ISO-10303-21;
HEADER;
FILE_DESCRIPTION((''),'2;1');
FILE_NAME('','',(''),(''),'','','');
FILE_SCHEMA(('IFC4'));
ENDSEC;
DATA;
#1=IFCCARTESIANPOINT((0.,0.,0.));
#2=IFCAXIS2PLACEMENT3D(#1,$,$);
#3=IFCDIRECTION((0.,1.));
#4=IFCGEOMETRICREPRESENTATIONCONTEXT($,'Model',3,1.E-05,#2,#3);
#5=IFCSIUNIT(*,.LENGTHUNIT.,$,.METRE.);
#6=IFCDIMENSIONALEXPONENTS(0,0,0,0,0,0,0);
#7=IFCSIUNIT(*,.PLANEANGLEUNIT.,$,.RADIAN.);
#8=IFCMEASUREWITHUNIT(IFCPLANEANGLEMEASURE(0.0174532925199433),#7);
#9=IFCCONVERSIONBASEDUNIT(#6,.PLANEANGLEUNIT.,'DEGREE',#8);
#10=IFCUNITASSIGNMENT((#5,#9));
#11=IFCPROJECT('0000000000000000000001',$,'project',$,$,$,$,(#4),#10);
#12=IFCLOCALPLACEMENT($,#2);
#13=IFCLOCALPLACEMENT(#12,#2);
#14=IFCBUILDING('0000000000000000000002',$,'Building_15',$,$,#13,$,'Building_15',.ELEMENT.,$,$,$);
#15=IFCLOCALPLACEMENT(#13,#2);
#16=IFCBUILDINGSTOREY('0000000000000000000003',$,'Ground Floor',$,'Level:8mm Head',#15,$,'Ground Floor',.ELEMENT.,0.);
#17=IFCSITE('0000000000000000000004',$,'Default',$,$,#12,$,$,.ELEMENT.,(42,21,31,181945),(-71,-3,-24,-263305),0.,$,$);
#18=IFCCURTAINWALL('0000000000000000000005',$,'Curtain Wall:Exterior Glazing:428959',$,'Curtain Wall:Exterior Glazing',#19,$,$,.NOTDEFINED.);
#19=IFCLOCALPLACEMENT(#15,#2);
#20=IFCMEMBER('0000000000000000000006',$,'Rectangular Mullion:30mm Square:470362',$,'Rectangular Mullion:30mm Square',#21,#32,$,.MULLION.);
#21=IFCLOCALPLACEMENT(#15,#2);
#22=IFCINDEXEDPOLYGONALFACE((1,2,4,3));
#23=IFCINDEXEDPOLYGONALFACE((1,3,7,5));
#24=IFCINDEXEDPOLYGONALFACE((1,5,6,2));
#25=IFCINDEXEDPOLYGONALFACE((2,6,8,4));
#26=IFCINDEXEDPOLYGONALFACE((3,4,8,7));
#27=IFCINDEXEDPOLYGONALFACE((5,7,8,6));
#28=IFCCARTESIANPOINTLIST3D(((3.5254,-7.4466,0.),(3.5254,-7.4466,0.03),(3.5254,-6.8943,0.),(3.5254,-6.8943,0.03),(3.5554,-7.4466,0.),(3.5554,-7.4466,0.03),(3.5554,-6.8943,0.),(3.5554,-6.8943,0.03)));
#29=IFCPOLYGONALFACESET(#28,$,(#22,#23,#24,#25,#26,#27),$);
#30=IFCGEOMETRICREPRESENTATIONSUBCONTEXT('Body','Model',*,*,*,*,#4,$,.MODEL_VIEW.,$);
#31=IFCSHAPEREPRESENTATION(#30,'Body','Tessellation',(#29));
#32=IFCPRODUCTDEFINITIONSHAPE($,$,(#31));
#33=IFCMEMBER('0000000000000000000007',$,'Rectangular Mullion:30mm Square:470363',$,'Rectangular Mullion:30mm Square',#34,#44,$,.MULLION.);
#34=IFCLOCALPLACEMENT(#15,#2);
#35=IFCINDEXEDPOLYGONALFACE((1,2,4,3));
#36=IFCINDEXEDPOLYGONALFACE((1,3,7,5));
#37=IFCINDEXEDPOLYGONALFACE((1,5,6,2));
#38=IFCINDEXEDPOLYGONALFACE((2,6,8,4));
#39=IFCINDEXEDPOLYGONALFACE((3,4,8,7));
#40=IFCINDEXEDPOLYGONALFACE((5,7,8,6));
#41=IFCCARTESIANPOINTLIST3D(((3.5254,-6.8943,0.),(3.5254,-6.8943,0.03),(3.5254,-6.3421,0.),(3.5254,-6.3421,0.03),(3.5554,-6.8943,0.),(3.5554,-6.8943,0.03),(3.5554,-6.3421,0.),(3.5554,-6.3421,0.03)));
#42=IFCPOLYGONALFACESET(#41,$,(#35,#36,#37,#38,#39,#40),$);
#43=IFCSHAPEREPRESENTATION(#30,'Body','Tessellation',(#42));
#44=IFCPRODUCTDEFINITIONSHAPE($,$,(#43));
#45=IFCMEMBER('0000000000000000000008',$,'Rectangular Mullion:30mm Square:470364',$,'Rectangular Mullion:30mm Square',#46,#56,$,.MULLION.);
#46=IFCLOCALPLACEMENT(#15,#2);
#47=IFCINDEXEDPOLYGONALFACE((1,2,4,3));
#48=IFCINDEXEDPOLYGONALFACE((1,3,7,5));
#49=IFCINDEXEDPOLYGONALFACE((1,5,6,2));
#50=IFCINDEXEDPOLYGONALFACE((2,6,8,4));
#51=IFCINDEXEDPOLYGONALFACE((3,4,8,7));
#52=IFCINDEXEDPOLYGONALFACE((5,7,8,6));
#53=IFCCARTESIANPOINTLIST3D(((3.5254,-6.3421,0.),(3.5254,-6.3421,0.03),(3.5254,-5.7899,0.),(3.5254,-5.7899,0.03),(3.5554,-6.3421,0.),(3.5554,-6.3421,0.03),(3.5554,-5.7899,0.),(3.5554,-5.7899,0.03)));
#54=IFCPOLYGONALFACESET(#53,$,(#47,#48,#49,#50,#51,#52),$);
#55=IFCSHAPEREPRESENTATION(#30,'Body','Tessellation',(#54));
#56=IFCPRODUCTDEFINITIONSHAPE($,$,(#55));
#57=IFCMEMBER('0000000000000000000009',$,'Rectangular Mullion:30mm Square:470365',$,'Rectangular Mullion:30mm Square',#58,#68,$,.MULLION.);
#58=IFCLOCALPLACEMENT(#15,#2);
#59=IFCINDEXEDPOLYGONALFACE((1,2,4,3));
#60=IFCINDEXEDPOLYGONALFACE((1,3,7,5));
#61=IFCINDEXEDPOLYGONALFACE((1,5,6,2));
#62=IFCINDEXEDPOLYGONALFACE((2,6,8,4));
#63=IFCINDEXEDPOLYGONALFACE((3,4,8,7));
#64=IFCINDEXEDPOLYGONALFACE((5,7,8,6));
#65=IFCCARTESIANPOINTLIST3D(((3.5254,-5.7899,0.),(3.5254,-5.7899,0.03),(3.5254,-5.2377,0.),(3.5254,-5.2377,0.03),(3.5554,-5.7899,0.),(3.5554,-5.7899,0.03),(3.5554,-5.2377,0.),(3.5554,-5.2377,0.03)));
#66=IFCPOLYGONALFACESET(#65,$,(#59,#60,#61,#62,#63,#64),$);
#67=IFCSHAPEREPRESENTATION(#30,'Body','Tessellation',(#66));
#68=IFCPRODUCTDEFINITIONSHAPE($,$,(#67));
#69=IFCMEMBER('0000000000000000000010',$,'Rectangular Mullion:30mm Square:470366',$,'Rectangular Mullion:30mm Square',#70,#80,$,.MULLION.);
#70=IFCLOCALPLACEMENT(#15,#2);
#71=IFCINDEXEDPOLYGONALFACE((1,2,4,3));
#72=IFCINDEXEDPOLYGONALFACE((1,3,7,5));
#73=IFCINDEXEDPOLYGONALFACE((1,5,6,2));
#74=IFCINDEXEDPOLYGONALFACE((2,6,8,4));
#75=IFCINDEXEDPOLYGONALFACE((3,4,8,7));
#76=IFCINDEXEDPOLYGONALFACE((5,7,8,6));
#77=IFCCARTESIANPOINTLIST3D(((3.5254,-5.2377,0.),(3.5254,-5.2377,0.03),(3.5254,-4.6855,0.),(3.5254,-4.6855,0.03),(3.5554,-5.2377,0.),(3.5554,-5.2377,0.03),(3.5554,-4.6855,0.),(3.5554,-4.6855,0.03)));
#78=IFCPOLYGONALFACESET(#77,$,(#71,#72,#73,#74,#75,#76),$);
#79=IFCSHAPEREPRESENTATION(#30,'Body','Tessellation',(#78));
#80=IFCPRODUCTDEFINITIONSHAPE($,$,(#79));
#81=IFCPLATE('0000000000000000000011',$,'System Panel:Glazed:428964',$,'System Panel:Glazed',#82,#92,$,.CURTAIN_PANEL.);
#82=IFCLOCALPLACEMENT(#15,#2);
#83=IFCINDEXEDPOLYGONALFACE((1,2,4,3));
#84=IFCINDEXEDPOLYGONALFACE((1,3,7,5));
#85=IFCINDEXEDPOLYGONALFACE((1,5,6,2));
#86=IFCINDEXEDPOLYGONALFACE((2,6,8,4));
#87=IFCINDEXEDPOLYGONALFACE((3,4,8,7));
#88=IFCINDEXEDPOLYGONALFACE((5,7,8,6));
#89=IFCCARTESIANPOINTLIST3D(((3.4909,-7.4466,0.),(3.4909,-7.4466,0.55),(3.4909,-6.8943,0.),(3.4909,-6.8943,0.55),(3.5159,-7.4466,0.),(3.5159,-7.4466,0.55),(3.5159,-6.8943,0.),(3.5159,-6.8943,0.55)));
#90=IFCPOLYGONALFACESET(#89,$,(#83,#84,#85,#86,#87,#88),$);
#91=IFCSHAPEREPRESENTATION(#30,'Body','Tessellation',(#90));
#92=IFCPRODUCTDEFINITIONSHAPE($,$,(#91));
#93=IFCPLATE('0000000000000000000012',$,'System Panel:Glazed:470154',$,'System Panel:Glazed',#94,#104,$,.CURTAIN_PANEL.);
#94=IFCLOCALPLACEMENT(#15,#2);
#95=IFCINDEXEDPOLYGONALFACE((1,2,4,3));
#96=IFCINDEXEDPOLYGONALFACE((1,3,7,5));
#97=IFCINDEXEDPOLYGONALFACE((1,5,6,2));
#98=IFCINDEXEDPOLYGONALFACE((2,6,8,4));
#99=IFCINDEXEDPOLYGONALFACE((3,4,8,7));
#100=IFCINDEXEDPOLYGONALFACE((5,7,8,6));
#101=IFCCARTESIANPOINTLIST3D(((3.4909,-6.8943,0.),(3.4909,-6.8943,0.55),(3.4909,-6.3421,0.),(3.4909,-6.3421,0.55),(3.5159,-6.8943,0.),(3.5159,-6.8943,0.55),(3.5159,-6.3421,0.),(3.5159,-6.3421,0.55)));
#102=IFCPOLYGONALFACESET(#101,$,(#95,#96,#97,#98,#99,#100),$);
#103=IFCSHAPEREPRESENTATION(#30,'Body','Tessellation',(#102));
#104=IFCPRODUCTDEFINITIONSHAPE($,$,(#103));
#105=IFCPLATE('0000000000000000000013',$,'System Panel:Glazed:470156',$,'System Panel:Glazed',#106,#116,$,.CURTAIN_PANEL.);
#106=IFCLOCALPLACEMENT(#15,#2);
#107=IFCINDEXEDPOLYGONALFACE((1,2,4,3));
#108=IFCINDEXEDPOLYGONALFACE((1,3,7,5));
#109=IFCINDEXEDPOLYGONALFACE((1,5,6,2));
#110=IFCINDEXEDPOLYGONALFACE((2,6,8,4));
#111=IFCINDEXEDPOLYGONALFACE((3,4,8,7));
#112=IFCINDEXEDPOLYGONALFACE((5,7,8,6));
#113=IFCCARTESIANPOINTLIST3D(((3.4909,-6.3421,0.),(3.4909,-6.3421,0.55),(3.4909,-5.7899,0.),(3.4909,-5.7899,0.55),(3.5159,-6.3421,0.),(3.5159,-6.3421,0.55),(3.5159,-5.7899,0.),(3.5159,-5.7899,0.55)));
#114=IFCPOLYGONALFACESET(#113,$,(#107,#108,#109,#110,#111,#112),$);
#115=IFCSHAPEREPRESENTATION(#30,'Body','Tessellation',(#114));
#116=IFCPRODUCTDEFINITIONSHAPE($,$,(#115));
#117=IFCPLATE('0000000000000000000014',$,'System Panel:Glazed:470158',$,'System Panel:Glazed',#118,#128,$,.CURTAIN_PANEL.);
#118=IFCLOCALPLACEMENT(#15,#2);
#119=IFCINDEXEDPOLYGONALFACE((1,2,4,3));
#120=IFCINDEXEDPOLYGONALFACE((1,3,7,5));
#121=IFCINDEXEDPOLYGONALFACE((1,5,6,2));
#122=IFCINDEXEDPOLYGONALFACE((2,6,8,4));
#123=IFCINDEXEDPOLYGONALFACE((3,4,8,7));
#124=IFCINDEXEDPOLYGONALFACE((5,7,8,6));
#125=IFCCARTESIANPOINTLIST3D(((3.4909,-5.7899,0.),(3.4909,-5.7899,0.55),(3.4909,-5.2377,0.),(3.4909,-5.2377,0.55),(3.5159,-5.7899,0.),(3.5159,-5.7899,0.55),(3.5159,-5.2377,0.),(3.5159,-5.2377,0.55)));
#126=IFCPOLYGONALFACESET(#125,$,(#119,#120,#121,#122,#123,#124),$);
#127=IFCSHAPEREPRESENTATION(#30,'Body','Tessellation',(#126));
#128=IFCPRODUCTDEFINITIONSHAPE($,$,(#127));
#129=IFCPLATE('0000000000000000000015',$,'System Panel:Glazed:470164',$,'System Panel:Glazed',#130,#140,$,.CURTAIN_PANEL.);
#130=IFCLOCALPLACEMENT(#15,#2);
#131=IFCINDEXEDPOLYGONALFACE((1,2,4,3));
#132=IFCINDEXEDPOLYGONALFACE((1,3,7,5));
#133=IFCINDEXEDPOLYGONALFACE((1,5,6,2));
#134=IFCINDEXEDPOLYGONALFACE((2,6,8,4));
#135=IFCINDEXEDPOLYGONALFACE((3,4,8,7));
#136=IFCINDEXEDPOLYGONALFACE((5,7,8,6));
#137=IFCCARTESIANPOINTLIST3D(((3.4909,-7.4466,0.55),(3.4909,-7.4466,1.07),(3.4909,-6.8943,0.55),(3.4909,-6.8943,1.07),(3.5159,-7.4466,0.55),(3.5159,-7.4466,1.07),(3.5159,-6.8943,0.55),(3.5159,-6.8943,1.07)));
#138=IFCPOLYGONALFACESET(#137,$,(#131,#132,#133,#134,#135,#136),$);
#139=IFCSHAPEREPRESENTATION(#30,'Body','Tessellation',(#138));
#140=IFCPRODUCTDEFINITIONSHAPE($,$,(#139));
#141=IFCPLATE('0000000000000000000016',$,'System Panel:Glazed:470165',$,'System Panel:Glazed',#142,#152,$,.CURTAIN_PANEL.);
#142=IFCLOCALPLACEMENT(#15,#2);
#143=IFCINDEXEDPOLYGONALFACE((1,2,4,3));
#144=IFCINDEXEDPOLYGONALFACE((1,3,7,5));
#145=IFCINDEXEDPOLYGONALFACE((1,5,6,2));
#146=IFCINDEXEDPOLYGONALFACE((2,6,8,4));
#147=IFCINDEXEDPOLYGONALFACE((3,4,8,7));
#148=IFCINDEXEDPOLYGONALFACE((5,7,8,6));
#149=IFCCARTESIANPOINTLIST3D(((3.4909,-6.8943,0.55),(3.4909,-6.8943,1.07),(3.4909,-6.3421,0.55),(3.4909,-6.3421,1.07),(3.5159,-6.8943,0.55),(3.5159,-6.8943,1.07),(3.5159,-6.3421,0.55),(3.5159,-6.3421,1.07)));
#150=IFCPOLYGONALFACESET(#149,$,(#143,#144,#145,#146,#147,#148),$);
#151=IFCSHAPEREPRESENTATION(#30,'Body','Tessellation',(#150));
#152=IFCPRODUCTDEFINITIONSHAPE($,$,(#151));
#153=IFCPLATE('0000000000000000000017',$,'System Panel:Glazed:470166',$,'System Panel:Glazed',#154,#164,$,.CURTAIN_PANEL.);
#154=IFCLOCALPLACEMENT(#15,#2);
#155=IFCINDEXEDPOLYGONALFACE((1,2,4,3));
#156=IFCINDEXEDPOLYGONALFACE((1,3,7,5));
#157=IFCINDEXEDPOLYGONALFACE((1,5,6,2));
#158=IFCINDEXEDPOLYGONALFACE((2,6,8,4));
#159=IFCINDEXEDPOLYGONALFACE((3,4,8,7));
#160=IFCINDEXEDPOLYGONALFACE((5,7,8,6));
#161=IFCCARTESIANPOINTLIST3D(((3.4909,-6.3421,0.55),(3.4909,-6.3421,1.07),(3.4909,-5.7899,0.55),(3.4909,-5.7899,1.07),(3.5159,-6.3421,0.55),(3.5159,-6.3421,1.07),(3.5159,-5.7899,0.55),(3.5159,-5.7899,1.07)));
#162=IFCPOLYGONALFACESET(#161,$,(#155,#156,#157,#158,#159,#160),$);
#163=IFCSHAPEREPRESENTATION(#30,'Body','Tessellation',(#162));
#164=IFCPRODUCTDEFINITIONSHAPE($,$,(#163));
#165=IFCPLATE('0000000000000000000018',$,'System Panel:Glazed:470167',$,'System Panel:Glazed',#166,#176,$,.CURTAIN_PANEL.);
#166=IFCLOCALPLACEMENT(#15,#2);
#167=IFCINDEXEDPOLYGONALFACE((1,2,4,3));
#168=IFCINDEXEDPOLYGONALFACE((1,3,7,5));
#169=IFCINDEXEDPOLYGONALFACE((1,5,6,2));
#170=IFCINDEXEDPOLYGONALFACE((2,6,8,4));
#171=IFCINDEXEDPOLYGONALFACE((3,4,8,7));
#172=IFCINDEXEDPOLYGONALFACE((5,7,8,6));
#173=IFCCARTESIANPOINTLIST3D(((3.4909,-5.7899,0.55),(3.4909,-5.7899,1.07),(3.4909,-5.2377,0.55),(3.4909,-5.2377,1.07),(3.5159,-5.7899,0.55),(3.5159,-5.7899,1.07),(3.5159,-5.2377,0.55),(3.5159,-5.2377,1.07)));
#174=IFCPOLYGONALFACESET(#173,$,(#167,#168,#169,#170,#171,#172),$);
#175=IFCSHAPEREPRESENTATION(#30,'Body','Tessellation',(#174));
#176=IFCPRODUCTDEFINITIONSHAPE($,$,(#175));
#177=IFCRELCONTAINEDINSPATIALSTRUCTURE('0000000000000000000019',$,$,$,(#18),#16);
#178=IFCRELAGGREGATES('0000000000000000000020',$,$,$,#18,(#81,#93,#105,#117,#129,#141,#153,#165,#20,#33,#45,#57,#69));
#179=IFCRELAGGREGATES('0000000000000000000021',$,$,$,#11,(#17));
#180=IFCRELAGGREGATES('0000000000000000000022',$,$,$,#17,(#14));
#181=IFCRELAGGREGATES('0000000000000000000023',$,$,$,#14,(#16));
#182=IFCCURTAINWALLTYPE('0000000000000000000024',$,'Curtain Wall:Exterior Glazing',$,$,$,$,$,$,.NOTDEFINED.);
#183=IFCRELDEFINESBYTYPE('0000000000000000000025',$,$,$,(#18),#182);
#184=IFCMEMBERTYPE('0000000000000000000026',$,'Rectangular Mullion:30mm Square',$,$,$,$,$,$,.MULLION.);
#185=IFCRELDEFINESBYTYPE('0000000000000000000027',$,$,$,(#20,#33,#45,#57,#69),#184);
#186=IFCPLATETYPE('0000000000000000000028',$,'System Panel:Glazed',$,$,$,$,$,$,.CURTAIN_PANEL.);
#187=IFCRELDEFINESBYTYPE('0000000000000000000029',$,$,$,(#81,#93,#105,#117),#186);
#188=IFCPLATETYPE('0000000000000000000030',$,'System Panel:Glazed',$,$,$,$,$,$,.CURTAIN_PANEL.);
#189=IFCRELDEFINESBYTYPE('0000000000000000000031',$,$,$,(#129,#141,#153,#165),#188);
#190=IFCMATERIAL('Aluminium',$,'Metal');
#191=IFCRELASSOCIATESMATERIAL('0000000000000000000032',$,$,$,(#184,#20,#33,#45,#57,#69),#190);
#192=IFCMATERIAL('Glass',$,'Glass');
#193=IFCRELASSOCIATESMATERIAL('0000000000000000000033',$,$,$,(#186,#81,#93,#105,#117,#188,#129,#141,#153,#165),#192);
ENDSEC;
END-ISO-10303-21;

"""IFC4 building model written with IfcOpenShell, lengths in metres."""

from ifc_helpers import new_model, entity, si_unit, converted_unit, direction, frame, origin, place, context, subcontext, project, spatial, indexed_curve, outline, extrude, source, transform, mapped, material, type_object, type_shapes, element, aggregate, save


model = new_model("IFC4")

# Units and contexts
model_context = context("Model", 3, precision=1e-05, world=origin(), true_north=direction((0.0, 1.0)))
body_context = subcontext(model_context, "Body", "Model", "MODEL_VIEW")
ifc_project = project(units=[si_unit("LENGTHUNIT", "METRE"), converted_unit("PLANEANGLEUNIT", "DEGREE", entity("IfcPlaneAngleMeasure", 0.0174532925199433), si_unit("PLANEANGLEUNIT", "RADIAN"), dimensions=[0, 0, 0, 0, 0, 0, 0])], contexts=[model_context])

# Site, building, storey
site_placement = place(None, origin())
site = spatial("IfcSite", under=ifc_project, at=site_placement, Name="Default", CompositionType="ELEMENT", RefLatitude=(42, 21, 31, 181945), RefLongitude=(-71, -3, -24, -263305), RefElevation=0.0)
building_placement = place(site_placement, origin())
building = spatial("IfcBuilding", under=site, at=building_placement, Name="Building_15", LongName="Building_15", CompositionType="ELEMENT")
storey_placement = place(building_placement, origin())
storey = spatial("IfcBuildingStorey", under=building, at=storey_placement, Name="Ground Floor", ObjectType="Level:8mm Head", LongName="Ground Floor", CompositionType="ELEMENT", Elevation=0.0)

# Curtain wall, members, plates
curtain_wall_type = type_object("IfcCurtainWallType", Name="Curtain Wall:Exterior Glazing", PredefinedType="NOTDEFINED")
curtain_wall_placement = place(storey_placement, origin())
curtain_wall = element("IfcCurtainWall", 1, at=curtain_wall_placement, inside=storey, type_object=curtain_wall_type, Name="Curtain Wall:Exterior Glazing:428959", ObjectType="Curtain Wall:Exterior Glazing", PredefinedType="NOTDEFINED")
ifc_material_1 = material(Name="Aluminium", Category="Metal")
member_type = type_object("IfcMemberType", Name="Rectangular Mullion:30mm Square", PredefinedType="MULLION", material=ifc_material_1)
shared_shape_1 = source(origin(), body_context, "Body", "SweptSolid", [
    extrude(outline(indexed_curve([(-0.015, -0.015), (0.015, -0.015), (0.015, 0.015), (-0.015, 0.015), (-0.015, -0.015)], self_intersect=False)), frame((-0.015, 0.0, -0.5522), z_axis=(0.0, 0.0, 1.0), x_axis=(-1.0, 0.0, 0.0)), (0.0, 0.0, 1.0), 0.5522),
])
type_shapes(member_type, [shared_shape_1])
member_1_placement = place(curtain_wall_placement, frame((3.5404, -7.4466, 0.0), z_axis=(0.0, -1.0, 0.0), x_axis=(0.0, 0.0, -1.0)))
member_1 = element("IfcMember", 2, at=member_1_placement, type_object=member_type, material=ifc_material_1, Name="Rectangular Mullion:30mm Square:470362", ObjectType="Rectangular Mullion:30mm Square", PredefinedType="MULLION", context=body_context, shape_type="MappedRepresentation", body=[
    mapped(shared_shape_1, transform((0.0, 0.0, 0.0), scale=1.0)),
])
member_2_placement = place(curtain_wall_placement, frame((3.5404, -6.8943, 0.0), z_axis=(0.0, -1.0, 0.0), x_axis=(0.0, 0.0, -1.0)))
member_2 = element("IfcMember", 3, at=member_2_placement, type_object=member_type, material=ifc_material_1, Name="Rectangular Mullion:30mm Square:470363", ObjectType="Rectangular Mullion:30mm Square", PredefinedType="MULLION", context=body_context, shape_type="MappedRepresentation", body=[
    mapped(shared_shape_1, transform((0.0, 0.0, 0.0), scale=1.0)),
])
member_3_placement = place(curtain_wall_placement, frame((3.5404, -6.3421, 0.0), z_axis=(0.0, -1.0, 0.0), x_axis=(0.0, 0.0, -1.0)))
member_3 = element("IfcMember", 4, at=member_3_placement, type_object=member_type, material=ifc_material_1, Name="Rectangular Mullion:30mm Square:470364", ObjectType="Rectangular Mullion:30mm Square", PredefinedType="MULLION", context=body_context, shape_type="MappedRepresentation", body=[
    mapped(shared_shape_1, transform((0.0, 0.0, 0.0), scale=1.0)),
])
member_4_placement = place(curtain_wall_placement, frame((3.5404, -5.7899, 0.0), z_axis=(0.0, -1.0, 0.0), x_axis=(0.0, 0.0, -1.0)))
member_4 = element("IfcMember", 5, at=member_4_placement, type_object=member_type, material=ifc_material_1, Name="Rectangular Mullion:30mm Square:470365", ObjectType="Rectangular Mullion:30mm Square", PredefinedType="MULLION", context=body_context, shape_type="MappedRepresentation", body=[
    mapped(shared_shape_1, transform((0.0, 0.0, 0.0), scale=1.0)),
])
member_5_placement = place(curtain_wall_placement, frame((3.5404, -5.2377, 0.0), z_axis=(0.0, -1.0, 0.0), x_axis=(0.0, 0.0, -1.0)))
member_5 = element("IfcMember", 6, at=member_5_placement, type_object=member_type, material=ifc_material_1, Name="Rectangular Mullion:30mm Square:470366", ObjectType="Rectangular Mullion:30mm Square", PredefinedType="MULLION", context=body_context, shape_type="MappedRepresentation", body=[
    mapped(shared_shape_1, transform((0.0, 0.0, 0.0), scale=1.0)),
])
ifc_material_2 = material(Name="Glass", Category="Glass")
plate_type_1 = type_object("IfcPlateType", Name="System Panel:Glazed", PredefinedType="CURTAIN_PANEL", material=ifc_material_2)
shared_shape_2 = source(origin(), body_context, "Body", "SweptSolid", [
    extrude(outline(indexed_curve([(-0.0125, -0.2761), (0.0125, -0.2761), (0.0125, 0.2761), (-0.0125, 0.2761), (-0.0125, -0.2761)], self_intersect=False)), frame((0.0, 0.037, 0.0), z_axis=(0.0, 0.0, 1.0), x_axis=(0.0, 1.0, 0.0)), (0.0, 0.0, 1.0), 0.55),
])
type_shapes(plate_type_1, [shared_shape_2])
plate_1_placement = place(curtain_wall_placement, frame((3.5404, -7.1705, 0.0), z_axis=(0.0, 0.0, 1.0), x_axis=(0.0, 1.0, 0.0)))
plate_1 = element("IfcPlate", 7, at=plate_1_placement, type_object=plate_type_1, material=ifc_material_2, Name="System Panel:Glazed:428964", ObjectType="System Panel:Glazed", PredefinedType="CURTAIN_PANEL", context=body_context, shape_type="MappedRepresentation", body=[
    mapped(shared_shape_2, transform((0.0, 0.0, 0.0), scale=1.0)),
])
plate_2_placement = place(curtain_wall_placement, frame((3.5404, -6.6182, 0.0), z_axis=(0.0, 0.0, 1.0), x_axis=(0.0, 1.0, 0.0)))
plate_2 = element("IfcPlate", 8, at=plate_2_placement, type_object=plate_type_1, material=ifc_material_2, Name="System Panel:Glazed:470154", ObjectType="System Panel:Glazed", PredefinedType="CURTAIN_PANEL", context=body_context, shape_type="MappedRepresentation", body=[
    mapped(shared_shape_2, transform((0.0, 0.0, 0.0), scale=1.0)),
])
plate_3_placement = place(curtain_wall_placement, frame((3.5404, -6.066, 0.0), z_axis=(0.0, 0.0, 1.0), x_axis=(0.0, 1.0, 0.0)))
plate_3 = element("IfcPlate", 9, at=plate_3_placement, type_object=plate_type_1, material=ifc_material_2, Name="System Panel:Glazed:470156", ObjectType="System Panel:Glazed", PredefinedType="CURTAIN_PANEL", context=body_context, shape_type="MappedRepresentation", body=[
    mapped(shared_shape_2, transform((0.0, 0.0, 0.0), scale=1.0)),
])
plate_4_placement = place(curtain_wall_placement, frame((3.5404, -5.5138, 0.0), z_axis=(0.0, 0.0, 1.0), x_axis=(0.0, 1.0, 0.0)))
plate_4 = element("IfcPlate", 10, at=plate_4_placement, type_object=plate_type_1, material=ifc_material_2, Name="System Panel:Glazed:470158", ObjectType="System Panel:Glazed", PredefinedType="CURTAIN_PANEL", context=body_context, shape_type="MappedRepresentation", body=[
    mapped(shared_shape_2, transform((0.0, 0.0, 0.0), scale=1.0)),
])
plate_type_2 = type_object("IfcPlateType", Name="System Panel:Glazed", PredefinedType="CURTAIN_PANEL", material=ifc_material_2)
shared_shape_3 = source(origin(), body_context, "Body", "SweptSolid", [
    extrude(outline(indexed_curve([(-0.0125, -0.2761), (0.0125, -0.2761), (0.0125, 0.2761), (-0.0125, 0.2761), (-0.0125, -0.2761)], self_intersect=False)), frame((0.0, 0.037, 0.0), z_axis=(0.0, 0.0, 1.0), x_axis=(0.0, 1.0, 0.0)), (0.0, 0.0, 1.0), 0.52),
])
type_shapes(plate_type_2, [shared_shape_3])
plate_5_placement = place(curtain_wall_placement, frame((3.5404, -7.1705, 0.55), z_axis=(0.0, 0.0, 1.0), x_axis=(0.0, 1.0, 0.0)))
plate_5 = element("IfcPlate", 11, at=plate_5_placement, type_object=plate_type_2, material=ifc_material_2, Name="System Panel:Glazed:470164", ObjectType="System Panel:Glazed", PredefinedType="CURTAIN_PANEL", context=body_context, shape_type="MappedRepresentation", body=[
    mapped(shared_shape_3, transform((0.0, 0.0, 0.0), scale=1.0)),
])
plate_6_placement = place(curtain_wall_placement, frame((3.5404, -6.6182, 0.55), z_axis=(0.0, 0.0, 1.0), x_axis=(0.0, 1.0, 0.0)))
plate_6 = element("IfcPlate", 12, at=plate_6_placement, type_object=plate_type_2, material=ifc_material_2, Name="System Panel:Glazed:470165", ObjectType="System Panel:Glazed", PredefinedType="CURTAIN_PANEL", context=body_context, shape_type="MappedRepresentation", body=[
    mapped(shared_shape_3, transform((0.0, 0.0, 0.0), scale=1.0)),
])
plate_7_placement = place(curtain_wall_placement, frame((3.5404, -6.066, 0.55), z_axis=(0.0, 0.0, 1.0), x_axis=(0.0, 1.0, 0.0)))
plate_7 = element("IfcPlate", 13, at=plate_7_placement, type_object=plate_type_2, material=ifc_material_2, Name="System Panel:Glazed:470166", ObjectType="System Panel:Glazed", PredefinedType="CURTAIN_PANEL", context=body_context, shape_type="MappedRepresentation", body=[
    mapped(shared_shape_3, transform((0.0, 0.0, 0.0), scale=1.0)),
])
plate_8_placement = place(curtain_wall_placement, frame((3.5404, -5.5138, 0.55), z_axis=(0.0, 0.0, 1.0), x_axis=(0.0, 1.0, 0.0)))
plate_8 = element("IfcPlate", 14, at=plate_8_placement, type_object=plate_type_2, material=ifc_material_2, Name="System Panel:Glazed:470167", ObjectType="System Panel:Glazed", PredefinedType="CURTAIN_PANEL", context=body_context, shape_type="MappedRepresentation", body=[
    mapped(shared_shape_3, transform((0.0, 0.0, 0.0), scale=1.0)),
])
aggregate(curtain_wall, [plate_1, plate_2, plate_3, plate_4, plate_5, plate_6, plate_7, plate_8, member_1, member_2, member_3, member_4, member_5])

save(model, "model.ifc")
